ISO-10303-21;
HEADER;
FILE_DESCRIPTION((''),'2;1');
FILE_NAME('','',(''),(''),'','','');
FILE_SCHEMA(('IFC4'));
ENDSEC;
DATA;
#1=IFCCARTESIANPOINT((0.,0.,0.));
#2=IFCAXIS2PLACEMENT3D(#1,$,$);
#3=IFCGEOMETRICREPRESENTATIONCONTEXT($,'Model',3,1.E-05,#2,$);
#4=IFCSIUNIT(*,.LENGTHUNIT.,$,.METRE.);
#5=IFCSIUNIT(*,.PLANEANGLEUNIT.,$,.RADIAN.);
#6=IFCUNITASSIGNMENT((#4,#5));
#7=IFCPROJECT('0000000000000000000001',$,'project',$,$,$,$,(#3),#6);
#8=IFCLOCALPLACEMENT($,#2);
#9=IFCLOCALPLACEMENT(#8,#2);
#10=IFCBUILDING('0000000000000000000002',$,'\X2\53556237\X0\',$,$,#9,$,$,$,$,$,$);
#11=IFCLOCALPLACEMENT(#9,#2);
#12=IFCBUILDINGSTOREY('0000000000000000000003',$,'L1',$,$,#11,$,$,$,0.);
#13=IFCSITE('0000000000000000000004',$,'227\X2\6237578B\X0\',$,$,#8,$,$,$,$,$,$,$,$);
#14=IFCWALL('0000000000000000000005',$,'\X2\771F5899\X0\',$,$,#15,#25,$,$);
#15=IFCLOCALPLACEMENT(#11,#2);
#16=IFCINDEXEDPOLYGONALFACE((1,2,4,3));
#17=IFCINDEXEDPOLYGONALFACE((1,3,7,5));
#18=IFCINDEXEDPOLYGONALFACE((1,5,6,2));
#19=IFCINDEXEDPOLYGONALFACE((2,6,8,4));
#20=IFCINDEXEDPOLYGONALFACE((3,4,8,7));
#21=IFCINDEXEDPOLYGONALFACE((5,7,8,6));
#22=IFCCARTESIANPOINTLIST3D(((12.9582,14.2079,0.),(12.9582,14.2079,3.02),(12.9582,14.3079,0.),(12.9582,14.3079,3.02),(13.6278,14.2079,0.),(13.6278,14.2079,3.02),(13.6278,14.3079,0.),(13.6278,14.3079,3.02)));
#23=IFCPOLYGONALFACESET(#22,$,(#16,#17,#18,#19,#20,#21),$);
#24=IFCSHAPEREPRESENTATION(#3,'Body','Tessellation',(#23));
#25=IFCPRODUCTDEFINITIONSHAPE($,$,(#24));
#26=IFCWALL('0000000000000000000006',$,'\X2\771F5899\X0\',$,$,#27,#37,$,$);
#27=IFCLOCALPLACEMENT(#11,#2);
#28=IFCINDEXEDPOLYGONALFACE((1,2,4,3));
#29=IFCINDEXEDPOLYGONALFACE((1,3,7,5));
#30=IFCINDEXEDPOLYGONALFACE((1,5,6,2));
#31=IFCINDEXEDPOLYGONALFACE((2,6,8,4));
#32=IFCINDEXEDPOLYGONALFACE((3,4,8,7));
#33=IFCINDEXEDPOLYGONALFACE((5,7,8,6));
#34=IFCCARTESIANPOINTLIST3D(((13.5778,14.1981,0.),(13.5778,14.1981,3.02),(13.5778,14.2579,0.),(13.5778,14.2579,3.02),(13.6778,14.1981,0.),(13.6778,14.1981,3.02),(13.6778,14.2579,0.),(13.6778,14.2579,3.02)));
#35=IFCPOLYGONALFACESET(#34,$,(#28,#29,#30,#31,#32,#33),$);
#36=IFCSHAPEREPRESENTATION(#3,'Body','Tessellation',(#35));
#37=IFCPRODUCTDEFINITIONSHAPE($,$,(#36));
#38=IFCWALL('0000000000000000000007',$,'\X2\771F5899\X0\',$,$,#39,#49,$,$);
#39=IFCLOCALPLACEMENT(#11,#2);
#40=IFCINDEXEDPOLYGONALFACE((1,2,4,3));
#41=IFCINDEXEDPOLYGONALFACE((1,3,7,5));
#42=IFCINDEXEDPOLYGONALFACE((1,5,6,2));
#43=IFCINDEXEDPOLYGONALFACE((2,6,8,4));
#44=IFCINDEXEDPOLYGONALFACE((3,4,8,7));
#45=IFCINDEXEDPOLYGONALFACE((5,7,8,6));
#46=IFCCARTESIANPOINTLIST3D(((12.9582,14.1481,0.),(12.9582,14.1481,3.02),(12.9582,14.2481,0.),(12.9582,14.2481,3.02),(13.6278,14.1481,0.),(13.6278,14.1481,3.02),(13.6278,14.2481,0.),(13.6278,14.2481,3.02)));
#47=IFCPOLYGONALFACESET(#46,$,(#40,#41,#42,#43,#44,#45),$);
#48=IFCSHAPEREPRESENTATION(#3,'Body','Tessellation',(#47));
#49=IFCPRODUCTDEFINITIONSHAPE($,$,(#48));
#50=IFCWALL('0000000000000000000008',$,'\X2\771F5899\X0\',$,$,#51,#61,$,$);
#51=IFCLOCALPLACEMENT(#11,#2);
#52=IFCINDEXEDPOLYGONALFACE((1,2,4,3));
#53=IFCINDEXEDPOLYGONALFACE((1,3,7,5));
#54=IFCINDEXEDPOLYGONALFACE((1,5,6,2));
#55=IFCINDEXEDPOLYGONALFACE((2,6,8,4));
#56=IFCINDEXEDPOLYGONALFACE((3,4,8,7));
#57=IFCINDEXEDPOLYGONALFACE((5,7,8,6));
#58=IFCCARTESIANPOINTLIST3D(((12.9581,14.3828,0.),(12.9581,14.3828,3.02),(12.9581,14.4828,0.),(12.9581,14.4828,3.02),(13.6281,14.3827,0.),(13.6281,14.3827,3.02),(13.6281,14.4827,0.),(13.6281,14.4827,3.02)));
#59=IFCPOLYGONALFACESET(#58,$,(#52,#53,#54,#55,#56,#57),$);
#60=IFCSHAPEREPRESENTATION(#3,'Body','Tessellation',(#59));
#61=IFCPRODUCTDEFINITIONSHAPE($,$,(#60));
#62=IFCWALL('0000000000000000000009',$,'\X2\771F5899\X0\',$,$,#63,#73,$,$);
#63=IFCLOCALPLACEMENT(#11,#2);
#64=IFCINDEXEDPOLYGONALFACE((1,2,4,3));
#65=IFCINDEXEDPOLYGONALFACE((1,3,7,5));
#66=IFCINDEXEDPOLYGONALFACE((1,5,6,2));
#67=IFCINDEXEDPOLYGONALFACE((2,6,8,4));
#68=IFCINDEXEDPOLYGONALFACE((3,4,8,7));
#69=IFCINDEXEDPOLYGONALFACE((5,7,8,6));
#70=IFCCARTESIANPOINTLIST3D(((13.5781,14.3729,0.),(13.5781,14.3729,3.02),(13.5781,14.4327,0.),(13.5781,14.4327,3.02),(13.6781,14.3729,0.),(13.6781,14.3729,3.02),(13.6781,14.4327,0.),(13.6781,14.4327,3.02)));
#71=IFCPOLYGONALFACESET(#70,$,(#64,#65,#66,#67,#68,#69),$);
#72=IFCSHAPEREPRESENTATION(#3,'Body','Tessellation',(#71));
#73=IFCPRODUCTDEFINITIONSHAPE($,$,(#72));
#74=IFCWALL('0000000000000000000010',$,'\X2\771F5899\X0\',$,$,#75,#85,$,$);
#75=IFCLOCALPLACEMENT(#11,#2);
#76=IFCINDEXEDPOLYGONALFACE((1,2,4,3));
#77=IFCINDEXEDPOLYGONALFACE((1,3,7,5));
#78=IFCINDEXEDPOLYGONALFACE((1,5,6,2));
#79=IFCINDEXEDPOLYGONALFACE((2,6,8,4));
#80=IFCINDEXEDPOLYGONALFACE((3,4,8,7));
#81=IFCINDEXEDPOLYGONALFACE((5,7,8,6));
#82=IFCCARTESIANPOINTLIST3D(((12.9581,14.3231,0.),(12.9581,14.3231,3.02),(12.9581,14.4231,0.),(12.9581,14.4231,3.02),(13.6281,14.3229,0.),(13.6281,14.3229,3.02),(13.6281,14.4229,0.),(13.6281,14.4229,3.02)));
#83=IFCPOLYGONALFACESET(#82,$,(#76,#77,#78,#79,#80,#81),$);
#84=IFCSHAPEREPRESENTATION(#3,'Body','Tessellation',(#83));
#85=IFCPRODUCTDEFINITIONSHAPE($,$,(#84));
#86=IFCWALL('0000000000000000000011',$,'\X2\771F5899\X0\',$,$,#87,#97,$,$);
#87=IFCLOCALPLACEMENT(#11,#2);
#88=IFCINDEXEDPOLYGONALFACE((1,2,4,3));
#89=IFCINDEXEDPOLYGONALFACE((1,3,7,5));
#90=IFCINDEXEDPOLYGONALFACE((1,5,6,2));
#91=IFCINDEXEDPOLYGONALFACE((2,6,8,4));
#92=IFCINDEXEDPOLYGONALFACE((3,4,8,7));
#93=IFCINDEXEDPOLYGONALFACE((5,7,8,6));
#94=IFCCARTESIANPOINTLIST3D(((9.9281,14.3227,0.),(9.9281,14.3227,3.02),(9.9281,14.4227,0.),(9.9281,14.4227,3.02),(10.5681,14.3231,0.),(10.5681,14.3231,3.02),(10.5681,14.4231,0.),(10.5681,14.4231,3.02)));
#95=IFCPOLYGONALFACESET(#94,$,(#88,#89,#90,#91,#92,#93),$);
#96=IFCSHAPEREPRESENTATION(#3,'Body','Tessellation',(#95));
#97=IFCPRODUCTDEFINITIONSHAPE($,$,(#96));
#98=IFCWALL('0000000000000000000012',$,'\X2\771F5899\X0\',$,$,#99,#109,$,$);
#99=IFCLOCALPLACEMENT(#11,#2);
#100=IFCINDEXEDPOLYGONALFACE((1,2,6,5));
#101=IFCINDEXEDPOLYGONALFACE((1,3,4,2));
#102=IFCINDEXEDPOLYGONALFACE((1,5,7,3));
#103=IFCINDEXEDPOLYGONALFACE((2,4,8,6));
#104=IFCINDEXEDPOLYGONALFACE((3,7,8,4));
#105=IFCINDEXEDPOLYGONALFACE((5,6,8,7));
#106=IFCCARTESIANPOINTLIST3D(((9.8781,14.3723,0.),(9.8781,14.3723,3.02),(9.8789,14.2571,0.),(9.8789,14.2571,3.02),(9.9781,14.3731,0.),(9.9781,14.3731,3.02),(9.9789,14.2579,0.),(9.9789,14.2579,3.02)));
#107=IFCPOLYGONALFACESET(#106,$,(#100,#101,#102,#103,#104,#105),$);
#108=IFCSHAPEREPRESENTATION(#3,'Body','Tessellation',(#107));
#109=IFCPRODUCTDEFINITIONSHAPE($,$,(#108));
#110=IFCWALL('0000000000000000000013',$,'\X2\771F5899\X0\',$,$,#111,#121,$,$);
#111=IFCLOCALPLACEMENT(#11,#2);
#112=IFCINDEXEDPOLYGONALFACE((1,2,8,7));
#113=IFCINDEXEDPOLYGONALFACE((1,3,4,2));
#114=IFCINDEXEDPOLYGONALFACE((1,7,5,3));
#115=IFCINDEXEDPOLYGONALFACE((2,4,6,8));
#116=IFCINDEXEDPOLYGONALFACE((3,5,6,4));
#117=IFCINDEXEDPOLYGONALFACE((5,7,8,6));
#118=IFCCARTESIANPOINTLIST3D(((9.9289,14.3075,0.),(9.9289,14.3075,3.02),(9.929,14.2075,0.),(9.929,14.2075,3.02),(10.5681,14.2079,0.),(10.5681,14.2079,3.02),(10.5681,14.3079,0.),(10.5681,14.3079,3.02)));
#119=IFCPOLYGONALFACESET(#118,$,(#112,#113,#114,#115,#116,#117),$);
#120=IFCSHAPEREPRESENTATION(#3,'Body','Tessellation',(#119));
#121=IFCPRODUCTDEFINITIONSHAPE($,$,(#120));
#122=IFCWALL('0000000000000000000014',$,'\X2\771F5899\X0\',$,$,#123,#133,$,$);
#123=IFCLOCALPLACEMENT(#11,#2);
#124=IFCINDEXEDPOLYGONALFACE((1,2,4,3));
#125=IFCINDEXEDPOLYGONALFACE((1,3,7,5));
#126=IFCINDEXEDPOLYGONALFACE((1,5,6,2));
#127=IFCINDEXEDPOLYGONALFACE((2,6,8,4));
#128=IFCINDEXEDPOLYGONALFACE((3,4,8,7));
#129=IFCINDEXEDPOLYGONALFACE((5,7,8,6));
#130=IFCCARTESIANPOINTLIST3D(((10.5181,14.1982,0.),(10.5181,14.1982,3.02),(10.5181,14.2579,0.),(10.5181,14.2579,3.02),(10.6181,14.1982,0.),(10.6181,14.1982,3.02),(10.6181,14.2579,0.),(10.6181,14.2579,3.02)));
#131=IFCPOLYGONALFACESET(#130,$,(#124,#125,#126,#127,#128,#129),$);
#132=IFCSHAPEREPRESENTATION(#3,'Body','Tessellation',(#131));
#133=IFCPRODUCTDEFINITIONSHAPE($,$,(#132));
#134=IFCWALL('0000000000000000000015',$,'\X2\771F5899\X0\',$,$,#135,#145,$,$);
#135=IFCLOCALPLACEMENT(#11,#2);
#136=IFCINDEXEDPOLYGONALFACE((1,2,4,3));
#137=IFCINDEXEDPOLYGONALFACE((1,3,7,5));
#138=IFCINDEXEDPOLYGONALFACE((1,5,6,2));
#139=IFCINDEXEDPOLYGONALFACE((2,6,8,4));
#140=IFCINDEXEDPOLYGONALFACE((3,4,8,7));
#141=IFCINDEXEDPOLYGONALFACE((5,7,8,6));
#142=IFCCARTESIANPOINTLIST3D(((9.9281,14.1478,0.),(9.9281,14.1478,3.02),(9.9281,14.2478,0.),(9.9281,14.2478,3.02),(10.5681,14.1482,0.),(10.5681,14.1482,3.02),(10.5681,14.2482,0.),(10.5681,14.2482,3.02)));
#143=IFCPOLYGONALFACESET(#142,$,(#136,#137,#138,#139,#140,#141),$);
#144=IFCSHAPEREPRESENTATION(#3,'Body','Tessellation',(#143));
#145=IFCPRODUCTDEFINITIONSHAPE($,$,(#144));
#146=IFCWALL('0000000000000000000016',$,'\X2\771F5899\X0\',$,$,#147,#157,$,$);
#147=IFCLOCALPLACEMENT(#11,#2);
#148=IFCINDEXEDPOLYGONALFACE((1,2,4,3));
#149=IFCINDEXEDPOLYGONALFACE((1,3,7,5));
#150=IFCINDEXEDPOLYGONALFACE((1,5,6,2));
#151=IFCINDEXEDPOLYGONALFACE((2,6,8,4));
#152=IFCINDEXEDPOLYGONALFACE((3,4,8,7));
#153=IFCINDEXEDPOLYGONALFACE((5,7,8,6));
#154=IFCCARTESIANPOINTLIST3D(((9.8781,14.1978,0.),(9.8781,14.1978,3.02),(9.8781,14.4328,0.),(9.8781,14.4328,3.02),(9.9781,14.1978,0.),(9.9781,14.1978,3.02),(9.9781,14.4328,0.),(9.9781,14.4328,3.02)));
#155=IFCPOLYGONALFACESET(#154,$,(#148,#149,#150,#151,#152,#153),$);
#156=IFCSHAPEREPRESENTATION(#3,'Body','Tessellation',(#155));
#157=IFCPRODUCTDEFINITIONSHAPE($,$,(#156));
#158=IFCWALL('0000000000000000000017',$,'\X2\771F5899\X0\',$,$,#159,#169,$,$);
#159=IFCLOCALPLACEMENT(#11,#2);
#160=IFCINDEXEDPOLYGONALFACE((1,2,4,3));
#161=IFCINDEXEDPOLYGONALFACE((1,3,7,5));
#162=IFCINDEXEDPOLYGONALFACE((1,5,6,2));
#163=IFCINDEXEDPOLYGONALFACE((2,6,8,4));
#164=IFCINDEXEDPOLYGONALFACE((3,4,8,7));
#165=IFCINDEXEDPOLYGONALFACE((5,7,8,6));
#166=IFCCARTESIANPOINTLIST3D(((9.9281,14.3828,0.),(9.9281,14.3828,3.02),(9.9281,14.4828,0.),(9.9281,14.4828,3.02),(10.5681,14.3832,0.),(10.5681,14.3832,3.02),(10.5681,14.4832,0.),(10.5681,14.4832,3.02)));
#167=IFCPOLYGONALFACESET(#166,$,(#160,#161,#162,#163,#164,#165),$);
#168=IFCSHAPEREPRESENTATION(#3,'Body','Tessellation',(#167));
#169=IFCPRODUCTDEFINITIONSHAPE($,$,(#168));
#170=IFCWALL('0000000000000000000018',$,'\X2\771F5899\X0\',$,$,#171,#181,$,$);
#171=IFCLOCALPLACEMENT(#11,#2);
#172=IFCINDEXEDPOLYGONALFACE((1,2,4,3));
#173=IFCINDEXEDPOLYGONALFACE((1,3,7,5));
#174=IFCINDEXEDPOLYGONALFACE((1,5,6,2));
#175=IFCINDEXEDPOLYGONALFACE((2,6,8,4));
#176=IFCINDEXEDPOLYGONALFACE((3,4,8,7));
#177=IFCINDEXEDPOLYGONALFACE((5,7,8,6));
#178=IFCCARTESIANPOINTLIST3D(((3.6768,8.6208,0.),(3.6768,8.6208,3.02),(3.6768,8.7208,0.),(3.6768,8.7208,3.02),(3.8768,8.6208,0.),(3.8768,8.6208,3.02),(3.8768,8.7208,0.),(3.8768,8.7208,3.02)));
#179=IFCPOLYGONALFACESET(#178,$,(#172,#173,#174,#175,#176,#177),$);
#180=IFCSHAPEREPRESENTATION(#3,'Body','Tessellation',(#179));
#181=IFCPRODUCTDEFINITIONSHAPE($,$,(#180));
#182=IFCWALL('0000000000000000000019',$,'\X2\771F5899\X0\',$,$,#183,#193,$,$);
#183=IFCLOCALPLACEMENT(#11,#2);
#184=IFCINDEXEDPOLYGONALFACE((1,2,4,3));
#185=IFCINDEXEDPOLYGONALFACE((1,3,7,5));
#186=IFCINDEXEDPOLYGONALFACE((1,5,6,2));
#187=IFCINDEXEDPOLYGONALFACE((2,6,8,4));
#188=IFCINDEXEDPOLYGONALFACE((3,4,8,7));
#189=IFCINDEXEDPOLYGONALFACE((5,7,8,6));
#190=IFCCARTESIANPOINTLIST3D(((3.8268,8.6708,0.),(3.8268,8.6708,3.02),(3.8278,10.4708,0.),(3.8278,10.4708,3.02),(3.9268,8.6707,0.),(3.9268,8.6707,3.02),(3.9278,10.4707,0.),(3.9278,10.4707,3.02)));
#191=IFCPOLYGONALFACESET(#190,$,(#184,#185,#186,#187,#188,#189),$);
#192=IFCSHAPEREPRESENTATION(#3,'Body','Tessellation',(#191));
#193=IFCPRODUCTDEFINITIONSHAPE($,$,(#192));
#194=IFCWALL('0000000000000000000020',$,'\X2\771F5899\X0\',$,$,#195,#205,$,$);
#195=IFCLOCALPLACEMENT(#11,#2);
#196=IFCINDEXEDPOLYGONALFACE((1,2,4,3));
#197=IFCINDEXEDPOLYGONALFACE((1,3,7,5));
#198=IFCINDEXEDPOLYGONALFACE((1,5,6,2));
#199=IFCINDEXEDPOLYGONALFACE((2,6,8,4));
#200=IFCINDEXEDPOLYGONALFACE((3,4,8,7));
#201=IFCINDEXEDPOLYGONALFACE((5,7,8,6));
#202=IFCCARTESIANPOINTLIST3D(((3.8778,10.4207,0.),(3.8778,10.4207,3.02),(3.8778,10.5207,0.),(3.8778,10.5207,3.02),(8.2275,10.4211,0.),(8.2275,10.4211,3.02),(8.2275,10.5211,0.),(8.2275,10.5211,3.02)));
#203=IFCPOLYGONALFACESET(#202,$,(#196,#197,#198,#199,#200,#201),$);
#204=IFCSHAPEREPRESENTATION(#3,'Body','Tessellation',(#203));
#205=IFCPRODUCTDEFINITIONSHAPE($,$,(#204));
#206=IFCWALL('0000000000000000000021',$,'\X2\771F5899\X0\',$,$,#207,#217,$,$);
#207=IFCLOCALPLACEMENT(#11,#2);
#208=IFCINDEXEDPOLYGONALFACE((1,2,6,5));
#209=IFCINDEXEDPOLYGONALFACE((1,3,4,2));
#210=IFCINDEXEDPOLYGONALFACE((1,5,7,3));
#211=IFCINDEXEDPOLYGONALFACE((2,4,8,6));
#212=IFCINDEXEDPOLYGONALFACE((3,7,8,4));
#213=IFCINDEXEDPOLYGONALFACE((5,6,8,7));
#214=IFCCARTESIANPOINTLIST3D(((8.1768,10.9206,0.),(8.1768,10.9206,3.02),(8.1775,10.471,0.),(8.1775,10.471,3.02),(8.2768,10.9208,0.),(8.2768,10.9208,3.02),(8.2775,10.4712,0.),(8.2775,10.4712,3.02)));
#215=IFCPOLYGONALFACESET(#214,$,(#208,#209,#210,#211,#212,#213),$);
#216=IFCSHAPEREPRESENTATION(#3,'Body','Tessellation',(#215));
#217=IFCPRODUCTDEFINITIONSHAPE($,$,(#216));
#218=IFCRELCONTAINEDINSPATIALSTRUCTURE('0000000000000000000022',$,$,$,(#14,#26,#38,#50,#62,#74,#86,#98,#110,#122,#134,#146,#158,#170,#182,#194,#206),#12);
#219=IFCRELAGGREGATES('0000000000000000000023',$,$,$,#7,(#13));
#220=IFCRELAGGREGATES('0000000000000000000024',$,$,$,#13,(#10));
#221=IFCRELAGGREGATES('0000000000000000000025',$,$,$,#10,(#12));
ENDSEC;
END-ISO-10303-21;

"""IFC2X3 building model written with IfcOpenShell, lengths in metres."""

from ifc_helpers import new_model, si_unit, origin, place, context, project, spatial, polyline, outline, extrude, element, save


model = new_model("IFC2X3")

# Units and contexts
model_context = context("Model", 3, precision=1e-05, world=origin())
ifc_project = project(units=[si_unit("LENGTHUNIT", "METRE"), si_unit("PLANEANGLEUNIT", "RADIAN")], contexts=[model_context])

# Site, building, storey
site_placement = place(None, origin())
site = spatial("IfcSite", under=ifc_project, at=site_placement, Name="227户型")
building_placement = place(site_placement, origin())
building = spatial("IfcBuilding", under=site, at=building_placement, Name="单户")
storey_placement = place(building_placement, origin())
storey = spatial("IfcBuildingStorey", under=building, at=storey_placement, Name="L1", Elevation=0.0)

# Walls
wall_1_placement = place(storey_placement, origin())
element("IfcWall", 1, at=wall_1_placement, inside=storey, Name="真墙", context=model_context, shape_type="SweptSolid", body=[
    extrude(outline(polyline([(12.9582, 14.3079), (13.6278, 14.3079), (13.6278, 14.2079), (12.9582, 14.2079), (12.9582, 14.3079)])), origin(), (0.0, 0.0, 1.0), 3.02),
])
wall_2_placement = place(storey_placement, origin())
element("IfcWall", 2, at=wall_2_placement, inside=storey, Name="真墙", context=model_context, shape_type="SweptSolid", body=[
    extrude(outline(polyline([(13.6778, 14.2579), (13.6778, 14.1981), (13.5778, 14.1981), (13.5778, 14.2579), (13.6778, 14.2579)])), origin(), (0.0, 0.0, 1.0), 3.02),
])
wall_3_placement = place(storey_placement, origin())
element("IfcWall", 3, at=wall_3_placement, inside=storey, Name="真墙", context=model_context, shape_type="SweptSolid", body=[
    extrude(outline(polyline([(13.6278, 14.1481), (12.9582, 14.1481), (12.9582, 14.2481), (13.6278, 14.2481), (13.6278, 14.1481)])), origin(), (0.0, 0.0, 1.0), 3.02),
])
wall_4_placement = place(storey_placement, origin())
element("IfcWall", 4, at=wall_4_placement, inside=storey, Name="真墙", context=model_context, shape_type="SweptSolid", body=[
    extrude(outline(polyline([(12.9581, 14.4828), (13.6281, 14.4827), (13.6281, 14.3827), (12.9581, 14.3828), (12.9581, 14.4828)])), origin(), (0.0, 0.0, 1.0), 3.02),
])
wall_5_placement = place(storey_placement, origin())
element("IfcWall", 5, at=wall_5_placement, inside=storey, Name="真墙", context=model_context, shape_type="SweptSolid", body=[
    extrude(outline(polyline([(13.6781, 14.4327), (13.6781, 14.3729), (13.5781, 14.3729), (13.5781, 14.4327), (13.6781, 14.4327)])), origin(), (0.0, 0.0, 1.0), 3.02),
])
wall_6_placement = place(storey_placement, origin())
element("IfcWall", 6, at=wall_6_placement, inside=storey, Name="真墙", context=model_context, shape_type="SweptSolid", body=[
    extrude(outline(polyline([(13.6281, 14.3229), (12.9581, 14.3231), (12.9581, 14.4231), (13.6281, 14.4229), (13.6281, 14.3229)])), origin(), (0.0, 0.0, 1.0), 3.02),
])
wall_7_placement = place(storey_placement, origin())
element("IfcWall", 7, at=wall_7_placement, inside=storey, Name="真墙", context=model_context, shape_type="SweptSolid", body=[
    extrude(outline(polyline([(10.5681, 14.3231), (9.9281, 14.3227), (9.9281, 14.4227), (10.5681, 14.4231), (10.5681, 14.3231)])), origin(), (0.0, 0.0, 1.0), 3.02),
])
wall_8_placement = place(storey_placement, origin())
element("IfcWall", 8, at=wall_8_placement, inside=storey, Name="真墙", context=model_context, shape_type="SweptSolid", body=[
    extrude(outline(polyline([(9.9781, 14.3731), (9.9789, 14.2579), (9.8789, 14.2571), (9.8781, 14.3723), (9.9781, 14.3731)])), origin(), (0.0, 0.0, 1.0), 3.02),
])
wall_9_placement = place(storey_placement, origin())
element("IfcWall", 9, at=wall_9_placement, inside=storey, Name="真墙", context=model_context, shape_type="SweptSolid", body=[
    extrude(outline(polyline([(9.9289, 14.3075), (10.5681, 14.3079), (10.5681, 14.2079), (9.929, 14.2075), (9.9289, 14.3075)])), origin(), (0.0, 0.0, 1.0), 3.02),
])
wall_10_placement = place(storey_placement, origin())
element("IfcWall", 10, at=wall_10_placement, inside=storey, Name="真墙", context=model_context, shape_type="SweptSolid", body=[
    extrude(outline(polyline([(10.6181, 14.2579), (10.6181, 14.1982), (10.5181, 14.1982), (10.5181, 14.2579), (10.6181, 14.2579)])), origin(), (0.0, 0.0, 1.0), 3.02),
])
wall_11_placement = place(storey_placement, origin())
element("IfcWall", 11, at=wall_11_placement, inside=storey, Name="真墙", context=model_context, shape_type="SweptSolid", body=[
    extrude(outline(polyline([(10.5681, 14.1482), (9.9281, 14.1478), (9.9281, 14.2478), (10.5681, 14.2482), (10.5681, 14.1482)])), origin(), (0.0, 0.0, 1.0), 3.02),
])
wall_12_placement = place(storey_placement, origin())
element("IfcWall", 12, at=wall_12_placement, inside=storey, Name="真墙", context=model_context, shape_type="SweptSolid", body=[
    extrude(outline(polyline([(9.8781, 14.1978), (9.8781, 14.4328), (9.9781, 14.4328), (9.9781, 14.1978), (9.8781, 14.1978)])), origin(), (0.0, 0.0, 1.0), 3.02),
])
wall_13_placement = place(storey_placement, origin())
element("IfcWall", 13, at=wall_13_placement, inside=storey, Name="真墙", context=model_context, shape_type="SweptSolid", body=[
    extrude(outline(polyline([(9.9281, 14.4828), (10.5681, 14.4832), (10.5681, 14.3832), (9.9281, 14.3828), (9.9281, 14.4828)])), origin(), (0.0, 0.0, 1.0), 3.02),
])
wall_14_placement = place(storey_placement, origin())
element("IfcWall", 14, at=wall_14_placement, inside=storey, Name="真墙", context=model_context, shape_type="SweptSolid", body=[
    extrude(outline(polyline([(3.6768, 8.7208), (3.8768, 8.7208), (3.8768, 8.6208), (3.6768, 8.6208), (3.6768, 8.7208)])), origin(), (0.0, 0.0, 1.0), 3.02),
])
wall_15_placement = place(storey_placement, origin())
element("IfcWall", 15, at=wall_15_placement, inside=storey, Name="真墙", context=model_context, shape_type="SweptSolid", body=[
    extrude(outline(polyline([(3.8268, 8.6708), (3.8278, 10.4708), (3.9278, 10.4707), (3.9268, 8.6707), (3.8268, 8.6708)])), origin(), (0.0, 0.0, 1.0), 3.02),
])
wall_16_placement = place(storey_placement, origin())
element("IfcWall", 16, at=wall_16_placement, inside=storey, Name="真墙", context=model_context, shape_type="SweptSolid", body=[
    extrude(outline(polyline([(3.8778, 10.5207), (8.2275, 10.5211), (8.2275, 10.4211), (3.8778, 10.4207), (3.8778, 10.5207)])), origin(), (0.0, 0.0, 1.0), 3.02),
])
wall_17_placement = place(storey_placement, origin())
element("IfcWall", 17, at=wall_17_placement, inside=storey, Name="真墙", context=model_context, shape_type="SweptSolid", body=[
    extrude(outline(polyline([(8.1775, 10.471), (8.1768, 10.9206), (8.2768, 10.9208), (8.2775, 10.4712), (8.1775, 10.471)])), origin(), (0.0, 0.0, 1.0), 3.02),
])

save(model, "model.ifc")
